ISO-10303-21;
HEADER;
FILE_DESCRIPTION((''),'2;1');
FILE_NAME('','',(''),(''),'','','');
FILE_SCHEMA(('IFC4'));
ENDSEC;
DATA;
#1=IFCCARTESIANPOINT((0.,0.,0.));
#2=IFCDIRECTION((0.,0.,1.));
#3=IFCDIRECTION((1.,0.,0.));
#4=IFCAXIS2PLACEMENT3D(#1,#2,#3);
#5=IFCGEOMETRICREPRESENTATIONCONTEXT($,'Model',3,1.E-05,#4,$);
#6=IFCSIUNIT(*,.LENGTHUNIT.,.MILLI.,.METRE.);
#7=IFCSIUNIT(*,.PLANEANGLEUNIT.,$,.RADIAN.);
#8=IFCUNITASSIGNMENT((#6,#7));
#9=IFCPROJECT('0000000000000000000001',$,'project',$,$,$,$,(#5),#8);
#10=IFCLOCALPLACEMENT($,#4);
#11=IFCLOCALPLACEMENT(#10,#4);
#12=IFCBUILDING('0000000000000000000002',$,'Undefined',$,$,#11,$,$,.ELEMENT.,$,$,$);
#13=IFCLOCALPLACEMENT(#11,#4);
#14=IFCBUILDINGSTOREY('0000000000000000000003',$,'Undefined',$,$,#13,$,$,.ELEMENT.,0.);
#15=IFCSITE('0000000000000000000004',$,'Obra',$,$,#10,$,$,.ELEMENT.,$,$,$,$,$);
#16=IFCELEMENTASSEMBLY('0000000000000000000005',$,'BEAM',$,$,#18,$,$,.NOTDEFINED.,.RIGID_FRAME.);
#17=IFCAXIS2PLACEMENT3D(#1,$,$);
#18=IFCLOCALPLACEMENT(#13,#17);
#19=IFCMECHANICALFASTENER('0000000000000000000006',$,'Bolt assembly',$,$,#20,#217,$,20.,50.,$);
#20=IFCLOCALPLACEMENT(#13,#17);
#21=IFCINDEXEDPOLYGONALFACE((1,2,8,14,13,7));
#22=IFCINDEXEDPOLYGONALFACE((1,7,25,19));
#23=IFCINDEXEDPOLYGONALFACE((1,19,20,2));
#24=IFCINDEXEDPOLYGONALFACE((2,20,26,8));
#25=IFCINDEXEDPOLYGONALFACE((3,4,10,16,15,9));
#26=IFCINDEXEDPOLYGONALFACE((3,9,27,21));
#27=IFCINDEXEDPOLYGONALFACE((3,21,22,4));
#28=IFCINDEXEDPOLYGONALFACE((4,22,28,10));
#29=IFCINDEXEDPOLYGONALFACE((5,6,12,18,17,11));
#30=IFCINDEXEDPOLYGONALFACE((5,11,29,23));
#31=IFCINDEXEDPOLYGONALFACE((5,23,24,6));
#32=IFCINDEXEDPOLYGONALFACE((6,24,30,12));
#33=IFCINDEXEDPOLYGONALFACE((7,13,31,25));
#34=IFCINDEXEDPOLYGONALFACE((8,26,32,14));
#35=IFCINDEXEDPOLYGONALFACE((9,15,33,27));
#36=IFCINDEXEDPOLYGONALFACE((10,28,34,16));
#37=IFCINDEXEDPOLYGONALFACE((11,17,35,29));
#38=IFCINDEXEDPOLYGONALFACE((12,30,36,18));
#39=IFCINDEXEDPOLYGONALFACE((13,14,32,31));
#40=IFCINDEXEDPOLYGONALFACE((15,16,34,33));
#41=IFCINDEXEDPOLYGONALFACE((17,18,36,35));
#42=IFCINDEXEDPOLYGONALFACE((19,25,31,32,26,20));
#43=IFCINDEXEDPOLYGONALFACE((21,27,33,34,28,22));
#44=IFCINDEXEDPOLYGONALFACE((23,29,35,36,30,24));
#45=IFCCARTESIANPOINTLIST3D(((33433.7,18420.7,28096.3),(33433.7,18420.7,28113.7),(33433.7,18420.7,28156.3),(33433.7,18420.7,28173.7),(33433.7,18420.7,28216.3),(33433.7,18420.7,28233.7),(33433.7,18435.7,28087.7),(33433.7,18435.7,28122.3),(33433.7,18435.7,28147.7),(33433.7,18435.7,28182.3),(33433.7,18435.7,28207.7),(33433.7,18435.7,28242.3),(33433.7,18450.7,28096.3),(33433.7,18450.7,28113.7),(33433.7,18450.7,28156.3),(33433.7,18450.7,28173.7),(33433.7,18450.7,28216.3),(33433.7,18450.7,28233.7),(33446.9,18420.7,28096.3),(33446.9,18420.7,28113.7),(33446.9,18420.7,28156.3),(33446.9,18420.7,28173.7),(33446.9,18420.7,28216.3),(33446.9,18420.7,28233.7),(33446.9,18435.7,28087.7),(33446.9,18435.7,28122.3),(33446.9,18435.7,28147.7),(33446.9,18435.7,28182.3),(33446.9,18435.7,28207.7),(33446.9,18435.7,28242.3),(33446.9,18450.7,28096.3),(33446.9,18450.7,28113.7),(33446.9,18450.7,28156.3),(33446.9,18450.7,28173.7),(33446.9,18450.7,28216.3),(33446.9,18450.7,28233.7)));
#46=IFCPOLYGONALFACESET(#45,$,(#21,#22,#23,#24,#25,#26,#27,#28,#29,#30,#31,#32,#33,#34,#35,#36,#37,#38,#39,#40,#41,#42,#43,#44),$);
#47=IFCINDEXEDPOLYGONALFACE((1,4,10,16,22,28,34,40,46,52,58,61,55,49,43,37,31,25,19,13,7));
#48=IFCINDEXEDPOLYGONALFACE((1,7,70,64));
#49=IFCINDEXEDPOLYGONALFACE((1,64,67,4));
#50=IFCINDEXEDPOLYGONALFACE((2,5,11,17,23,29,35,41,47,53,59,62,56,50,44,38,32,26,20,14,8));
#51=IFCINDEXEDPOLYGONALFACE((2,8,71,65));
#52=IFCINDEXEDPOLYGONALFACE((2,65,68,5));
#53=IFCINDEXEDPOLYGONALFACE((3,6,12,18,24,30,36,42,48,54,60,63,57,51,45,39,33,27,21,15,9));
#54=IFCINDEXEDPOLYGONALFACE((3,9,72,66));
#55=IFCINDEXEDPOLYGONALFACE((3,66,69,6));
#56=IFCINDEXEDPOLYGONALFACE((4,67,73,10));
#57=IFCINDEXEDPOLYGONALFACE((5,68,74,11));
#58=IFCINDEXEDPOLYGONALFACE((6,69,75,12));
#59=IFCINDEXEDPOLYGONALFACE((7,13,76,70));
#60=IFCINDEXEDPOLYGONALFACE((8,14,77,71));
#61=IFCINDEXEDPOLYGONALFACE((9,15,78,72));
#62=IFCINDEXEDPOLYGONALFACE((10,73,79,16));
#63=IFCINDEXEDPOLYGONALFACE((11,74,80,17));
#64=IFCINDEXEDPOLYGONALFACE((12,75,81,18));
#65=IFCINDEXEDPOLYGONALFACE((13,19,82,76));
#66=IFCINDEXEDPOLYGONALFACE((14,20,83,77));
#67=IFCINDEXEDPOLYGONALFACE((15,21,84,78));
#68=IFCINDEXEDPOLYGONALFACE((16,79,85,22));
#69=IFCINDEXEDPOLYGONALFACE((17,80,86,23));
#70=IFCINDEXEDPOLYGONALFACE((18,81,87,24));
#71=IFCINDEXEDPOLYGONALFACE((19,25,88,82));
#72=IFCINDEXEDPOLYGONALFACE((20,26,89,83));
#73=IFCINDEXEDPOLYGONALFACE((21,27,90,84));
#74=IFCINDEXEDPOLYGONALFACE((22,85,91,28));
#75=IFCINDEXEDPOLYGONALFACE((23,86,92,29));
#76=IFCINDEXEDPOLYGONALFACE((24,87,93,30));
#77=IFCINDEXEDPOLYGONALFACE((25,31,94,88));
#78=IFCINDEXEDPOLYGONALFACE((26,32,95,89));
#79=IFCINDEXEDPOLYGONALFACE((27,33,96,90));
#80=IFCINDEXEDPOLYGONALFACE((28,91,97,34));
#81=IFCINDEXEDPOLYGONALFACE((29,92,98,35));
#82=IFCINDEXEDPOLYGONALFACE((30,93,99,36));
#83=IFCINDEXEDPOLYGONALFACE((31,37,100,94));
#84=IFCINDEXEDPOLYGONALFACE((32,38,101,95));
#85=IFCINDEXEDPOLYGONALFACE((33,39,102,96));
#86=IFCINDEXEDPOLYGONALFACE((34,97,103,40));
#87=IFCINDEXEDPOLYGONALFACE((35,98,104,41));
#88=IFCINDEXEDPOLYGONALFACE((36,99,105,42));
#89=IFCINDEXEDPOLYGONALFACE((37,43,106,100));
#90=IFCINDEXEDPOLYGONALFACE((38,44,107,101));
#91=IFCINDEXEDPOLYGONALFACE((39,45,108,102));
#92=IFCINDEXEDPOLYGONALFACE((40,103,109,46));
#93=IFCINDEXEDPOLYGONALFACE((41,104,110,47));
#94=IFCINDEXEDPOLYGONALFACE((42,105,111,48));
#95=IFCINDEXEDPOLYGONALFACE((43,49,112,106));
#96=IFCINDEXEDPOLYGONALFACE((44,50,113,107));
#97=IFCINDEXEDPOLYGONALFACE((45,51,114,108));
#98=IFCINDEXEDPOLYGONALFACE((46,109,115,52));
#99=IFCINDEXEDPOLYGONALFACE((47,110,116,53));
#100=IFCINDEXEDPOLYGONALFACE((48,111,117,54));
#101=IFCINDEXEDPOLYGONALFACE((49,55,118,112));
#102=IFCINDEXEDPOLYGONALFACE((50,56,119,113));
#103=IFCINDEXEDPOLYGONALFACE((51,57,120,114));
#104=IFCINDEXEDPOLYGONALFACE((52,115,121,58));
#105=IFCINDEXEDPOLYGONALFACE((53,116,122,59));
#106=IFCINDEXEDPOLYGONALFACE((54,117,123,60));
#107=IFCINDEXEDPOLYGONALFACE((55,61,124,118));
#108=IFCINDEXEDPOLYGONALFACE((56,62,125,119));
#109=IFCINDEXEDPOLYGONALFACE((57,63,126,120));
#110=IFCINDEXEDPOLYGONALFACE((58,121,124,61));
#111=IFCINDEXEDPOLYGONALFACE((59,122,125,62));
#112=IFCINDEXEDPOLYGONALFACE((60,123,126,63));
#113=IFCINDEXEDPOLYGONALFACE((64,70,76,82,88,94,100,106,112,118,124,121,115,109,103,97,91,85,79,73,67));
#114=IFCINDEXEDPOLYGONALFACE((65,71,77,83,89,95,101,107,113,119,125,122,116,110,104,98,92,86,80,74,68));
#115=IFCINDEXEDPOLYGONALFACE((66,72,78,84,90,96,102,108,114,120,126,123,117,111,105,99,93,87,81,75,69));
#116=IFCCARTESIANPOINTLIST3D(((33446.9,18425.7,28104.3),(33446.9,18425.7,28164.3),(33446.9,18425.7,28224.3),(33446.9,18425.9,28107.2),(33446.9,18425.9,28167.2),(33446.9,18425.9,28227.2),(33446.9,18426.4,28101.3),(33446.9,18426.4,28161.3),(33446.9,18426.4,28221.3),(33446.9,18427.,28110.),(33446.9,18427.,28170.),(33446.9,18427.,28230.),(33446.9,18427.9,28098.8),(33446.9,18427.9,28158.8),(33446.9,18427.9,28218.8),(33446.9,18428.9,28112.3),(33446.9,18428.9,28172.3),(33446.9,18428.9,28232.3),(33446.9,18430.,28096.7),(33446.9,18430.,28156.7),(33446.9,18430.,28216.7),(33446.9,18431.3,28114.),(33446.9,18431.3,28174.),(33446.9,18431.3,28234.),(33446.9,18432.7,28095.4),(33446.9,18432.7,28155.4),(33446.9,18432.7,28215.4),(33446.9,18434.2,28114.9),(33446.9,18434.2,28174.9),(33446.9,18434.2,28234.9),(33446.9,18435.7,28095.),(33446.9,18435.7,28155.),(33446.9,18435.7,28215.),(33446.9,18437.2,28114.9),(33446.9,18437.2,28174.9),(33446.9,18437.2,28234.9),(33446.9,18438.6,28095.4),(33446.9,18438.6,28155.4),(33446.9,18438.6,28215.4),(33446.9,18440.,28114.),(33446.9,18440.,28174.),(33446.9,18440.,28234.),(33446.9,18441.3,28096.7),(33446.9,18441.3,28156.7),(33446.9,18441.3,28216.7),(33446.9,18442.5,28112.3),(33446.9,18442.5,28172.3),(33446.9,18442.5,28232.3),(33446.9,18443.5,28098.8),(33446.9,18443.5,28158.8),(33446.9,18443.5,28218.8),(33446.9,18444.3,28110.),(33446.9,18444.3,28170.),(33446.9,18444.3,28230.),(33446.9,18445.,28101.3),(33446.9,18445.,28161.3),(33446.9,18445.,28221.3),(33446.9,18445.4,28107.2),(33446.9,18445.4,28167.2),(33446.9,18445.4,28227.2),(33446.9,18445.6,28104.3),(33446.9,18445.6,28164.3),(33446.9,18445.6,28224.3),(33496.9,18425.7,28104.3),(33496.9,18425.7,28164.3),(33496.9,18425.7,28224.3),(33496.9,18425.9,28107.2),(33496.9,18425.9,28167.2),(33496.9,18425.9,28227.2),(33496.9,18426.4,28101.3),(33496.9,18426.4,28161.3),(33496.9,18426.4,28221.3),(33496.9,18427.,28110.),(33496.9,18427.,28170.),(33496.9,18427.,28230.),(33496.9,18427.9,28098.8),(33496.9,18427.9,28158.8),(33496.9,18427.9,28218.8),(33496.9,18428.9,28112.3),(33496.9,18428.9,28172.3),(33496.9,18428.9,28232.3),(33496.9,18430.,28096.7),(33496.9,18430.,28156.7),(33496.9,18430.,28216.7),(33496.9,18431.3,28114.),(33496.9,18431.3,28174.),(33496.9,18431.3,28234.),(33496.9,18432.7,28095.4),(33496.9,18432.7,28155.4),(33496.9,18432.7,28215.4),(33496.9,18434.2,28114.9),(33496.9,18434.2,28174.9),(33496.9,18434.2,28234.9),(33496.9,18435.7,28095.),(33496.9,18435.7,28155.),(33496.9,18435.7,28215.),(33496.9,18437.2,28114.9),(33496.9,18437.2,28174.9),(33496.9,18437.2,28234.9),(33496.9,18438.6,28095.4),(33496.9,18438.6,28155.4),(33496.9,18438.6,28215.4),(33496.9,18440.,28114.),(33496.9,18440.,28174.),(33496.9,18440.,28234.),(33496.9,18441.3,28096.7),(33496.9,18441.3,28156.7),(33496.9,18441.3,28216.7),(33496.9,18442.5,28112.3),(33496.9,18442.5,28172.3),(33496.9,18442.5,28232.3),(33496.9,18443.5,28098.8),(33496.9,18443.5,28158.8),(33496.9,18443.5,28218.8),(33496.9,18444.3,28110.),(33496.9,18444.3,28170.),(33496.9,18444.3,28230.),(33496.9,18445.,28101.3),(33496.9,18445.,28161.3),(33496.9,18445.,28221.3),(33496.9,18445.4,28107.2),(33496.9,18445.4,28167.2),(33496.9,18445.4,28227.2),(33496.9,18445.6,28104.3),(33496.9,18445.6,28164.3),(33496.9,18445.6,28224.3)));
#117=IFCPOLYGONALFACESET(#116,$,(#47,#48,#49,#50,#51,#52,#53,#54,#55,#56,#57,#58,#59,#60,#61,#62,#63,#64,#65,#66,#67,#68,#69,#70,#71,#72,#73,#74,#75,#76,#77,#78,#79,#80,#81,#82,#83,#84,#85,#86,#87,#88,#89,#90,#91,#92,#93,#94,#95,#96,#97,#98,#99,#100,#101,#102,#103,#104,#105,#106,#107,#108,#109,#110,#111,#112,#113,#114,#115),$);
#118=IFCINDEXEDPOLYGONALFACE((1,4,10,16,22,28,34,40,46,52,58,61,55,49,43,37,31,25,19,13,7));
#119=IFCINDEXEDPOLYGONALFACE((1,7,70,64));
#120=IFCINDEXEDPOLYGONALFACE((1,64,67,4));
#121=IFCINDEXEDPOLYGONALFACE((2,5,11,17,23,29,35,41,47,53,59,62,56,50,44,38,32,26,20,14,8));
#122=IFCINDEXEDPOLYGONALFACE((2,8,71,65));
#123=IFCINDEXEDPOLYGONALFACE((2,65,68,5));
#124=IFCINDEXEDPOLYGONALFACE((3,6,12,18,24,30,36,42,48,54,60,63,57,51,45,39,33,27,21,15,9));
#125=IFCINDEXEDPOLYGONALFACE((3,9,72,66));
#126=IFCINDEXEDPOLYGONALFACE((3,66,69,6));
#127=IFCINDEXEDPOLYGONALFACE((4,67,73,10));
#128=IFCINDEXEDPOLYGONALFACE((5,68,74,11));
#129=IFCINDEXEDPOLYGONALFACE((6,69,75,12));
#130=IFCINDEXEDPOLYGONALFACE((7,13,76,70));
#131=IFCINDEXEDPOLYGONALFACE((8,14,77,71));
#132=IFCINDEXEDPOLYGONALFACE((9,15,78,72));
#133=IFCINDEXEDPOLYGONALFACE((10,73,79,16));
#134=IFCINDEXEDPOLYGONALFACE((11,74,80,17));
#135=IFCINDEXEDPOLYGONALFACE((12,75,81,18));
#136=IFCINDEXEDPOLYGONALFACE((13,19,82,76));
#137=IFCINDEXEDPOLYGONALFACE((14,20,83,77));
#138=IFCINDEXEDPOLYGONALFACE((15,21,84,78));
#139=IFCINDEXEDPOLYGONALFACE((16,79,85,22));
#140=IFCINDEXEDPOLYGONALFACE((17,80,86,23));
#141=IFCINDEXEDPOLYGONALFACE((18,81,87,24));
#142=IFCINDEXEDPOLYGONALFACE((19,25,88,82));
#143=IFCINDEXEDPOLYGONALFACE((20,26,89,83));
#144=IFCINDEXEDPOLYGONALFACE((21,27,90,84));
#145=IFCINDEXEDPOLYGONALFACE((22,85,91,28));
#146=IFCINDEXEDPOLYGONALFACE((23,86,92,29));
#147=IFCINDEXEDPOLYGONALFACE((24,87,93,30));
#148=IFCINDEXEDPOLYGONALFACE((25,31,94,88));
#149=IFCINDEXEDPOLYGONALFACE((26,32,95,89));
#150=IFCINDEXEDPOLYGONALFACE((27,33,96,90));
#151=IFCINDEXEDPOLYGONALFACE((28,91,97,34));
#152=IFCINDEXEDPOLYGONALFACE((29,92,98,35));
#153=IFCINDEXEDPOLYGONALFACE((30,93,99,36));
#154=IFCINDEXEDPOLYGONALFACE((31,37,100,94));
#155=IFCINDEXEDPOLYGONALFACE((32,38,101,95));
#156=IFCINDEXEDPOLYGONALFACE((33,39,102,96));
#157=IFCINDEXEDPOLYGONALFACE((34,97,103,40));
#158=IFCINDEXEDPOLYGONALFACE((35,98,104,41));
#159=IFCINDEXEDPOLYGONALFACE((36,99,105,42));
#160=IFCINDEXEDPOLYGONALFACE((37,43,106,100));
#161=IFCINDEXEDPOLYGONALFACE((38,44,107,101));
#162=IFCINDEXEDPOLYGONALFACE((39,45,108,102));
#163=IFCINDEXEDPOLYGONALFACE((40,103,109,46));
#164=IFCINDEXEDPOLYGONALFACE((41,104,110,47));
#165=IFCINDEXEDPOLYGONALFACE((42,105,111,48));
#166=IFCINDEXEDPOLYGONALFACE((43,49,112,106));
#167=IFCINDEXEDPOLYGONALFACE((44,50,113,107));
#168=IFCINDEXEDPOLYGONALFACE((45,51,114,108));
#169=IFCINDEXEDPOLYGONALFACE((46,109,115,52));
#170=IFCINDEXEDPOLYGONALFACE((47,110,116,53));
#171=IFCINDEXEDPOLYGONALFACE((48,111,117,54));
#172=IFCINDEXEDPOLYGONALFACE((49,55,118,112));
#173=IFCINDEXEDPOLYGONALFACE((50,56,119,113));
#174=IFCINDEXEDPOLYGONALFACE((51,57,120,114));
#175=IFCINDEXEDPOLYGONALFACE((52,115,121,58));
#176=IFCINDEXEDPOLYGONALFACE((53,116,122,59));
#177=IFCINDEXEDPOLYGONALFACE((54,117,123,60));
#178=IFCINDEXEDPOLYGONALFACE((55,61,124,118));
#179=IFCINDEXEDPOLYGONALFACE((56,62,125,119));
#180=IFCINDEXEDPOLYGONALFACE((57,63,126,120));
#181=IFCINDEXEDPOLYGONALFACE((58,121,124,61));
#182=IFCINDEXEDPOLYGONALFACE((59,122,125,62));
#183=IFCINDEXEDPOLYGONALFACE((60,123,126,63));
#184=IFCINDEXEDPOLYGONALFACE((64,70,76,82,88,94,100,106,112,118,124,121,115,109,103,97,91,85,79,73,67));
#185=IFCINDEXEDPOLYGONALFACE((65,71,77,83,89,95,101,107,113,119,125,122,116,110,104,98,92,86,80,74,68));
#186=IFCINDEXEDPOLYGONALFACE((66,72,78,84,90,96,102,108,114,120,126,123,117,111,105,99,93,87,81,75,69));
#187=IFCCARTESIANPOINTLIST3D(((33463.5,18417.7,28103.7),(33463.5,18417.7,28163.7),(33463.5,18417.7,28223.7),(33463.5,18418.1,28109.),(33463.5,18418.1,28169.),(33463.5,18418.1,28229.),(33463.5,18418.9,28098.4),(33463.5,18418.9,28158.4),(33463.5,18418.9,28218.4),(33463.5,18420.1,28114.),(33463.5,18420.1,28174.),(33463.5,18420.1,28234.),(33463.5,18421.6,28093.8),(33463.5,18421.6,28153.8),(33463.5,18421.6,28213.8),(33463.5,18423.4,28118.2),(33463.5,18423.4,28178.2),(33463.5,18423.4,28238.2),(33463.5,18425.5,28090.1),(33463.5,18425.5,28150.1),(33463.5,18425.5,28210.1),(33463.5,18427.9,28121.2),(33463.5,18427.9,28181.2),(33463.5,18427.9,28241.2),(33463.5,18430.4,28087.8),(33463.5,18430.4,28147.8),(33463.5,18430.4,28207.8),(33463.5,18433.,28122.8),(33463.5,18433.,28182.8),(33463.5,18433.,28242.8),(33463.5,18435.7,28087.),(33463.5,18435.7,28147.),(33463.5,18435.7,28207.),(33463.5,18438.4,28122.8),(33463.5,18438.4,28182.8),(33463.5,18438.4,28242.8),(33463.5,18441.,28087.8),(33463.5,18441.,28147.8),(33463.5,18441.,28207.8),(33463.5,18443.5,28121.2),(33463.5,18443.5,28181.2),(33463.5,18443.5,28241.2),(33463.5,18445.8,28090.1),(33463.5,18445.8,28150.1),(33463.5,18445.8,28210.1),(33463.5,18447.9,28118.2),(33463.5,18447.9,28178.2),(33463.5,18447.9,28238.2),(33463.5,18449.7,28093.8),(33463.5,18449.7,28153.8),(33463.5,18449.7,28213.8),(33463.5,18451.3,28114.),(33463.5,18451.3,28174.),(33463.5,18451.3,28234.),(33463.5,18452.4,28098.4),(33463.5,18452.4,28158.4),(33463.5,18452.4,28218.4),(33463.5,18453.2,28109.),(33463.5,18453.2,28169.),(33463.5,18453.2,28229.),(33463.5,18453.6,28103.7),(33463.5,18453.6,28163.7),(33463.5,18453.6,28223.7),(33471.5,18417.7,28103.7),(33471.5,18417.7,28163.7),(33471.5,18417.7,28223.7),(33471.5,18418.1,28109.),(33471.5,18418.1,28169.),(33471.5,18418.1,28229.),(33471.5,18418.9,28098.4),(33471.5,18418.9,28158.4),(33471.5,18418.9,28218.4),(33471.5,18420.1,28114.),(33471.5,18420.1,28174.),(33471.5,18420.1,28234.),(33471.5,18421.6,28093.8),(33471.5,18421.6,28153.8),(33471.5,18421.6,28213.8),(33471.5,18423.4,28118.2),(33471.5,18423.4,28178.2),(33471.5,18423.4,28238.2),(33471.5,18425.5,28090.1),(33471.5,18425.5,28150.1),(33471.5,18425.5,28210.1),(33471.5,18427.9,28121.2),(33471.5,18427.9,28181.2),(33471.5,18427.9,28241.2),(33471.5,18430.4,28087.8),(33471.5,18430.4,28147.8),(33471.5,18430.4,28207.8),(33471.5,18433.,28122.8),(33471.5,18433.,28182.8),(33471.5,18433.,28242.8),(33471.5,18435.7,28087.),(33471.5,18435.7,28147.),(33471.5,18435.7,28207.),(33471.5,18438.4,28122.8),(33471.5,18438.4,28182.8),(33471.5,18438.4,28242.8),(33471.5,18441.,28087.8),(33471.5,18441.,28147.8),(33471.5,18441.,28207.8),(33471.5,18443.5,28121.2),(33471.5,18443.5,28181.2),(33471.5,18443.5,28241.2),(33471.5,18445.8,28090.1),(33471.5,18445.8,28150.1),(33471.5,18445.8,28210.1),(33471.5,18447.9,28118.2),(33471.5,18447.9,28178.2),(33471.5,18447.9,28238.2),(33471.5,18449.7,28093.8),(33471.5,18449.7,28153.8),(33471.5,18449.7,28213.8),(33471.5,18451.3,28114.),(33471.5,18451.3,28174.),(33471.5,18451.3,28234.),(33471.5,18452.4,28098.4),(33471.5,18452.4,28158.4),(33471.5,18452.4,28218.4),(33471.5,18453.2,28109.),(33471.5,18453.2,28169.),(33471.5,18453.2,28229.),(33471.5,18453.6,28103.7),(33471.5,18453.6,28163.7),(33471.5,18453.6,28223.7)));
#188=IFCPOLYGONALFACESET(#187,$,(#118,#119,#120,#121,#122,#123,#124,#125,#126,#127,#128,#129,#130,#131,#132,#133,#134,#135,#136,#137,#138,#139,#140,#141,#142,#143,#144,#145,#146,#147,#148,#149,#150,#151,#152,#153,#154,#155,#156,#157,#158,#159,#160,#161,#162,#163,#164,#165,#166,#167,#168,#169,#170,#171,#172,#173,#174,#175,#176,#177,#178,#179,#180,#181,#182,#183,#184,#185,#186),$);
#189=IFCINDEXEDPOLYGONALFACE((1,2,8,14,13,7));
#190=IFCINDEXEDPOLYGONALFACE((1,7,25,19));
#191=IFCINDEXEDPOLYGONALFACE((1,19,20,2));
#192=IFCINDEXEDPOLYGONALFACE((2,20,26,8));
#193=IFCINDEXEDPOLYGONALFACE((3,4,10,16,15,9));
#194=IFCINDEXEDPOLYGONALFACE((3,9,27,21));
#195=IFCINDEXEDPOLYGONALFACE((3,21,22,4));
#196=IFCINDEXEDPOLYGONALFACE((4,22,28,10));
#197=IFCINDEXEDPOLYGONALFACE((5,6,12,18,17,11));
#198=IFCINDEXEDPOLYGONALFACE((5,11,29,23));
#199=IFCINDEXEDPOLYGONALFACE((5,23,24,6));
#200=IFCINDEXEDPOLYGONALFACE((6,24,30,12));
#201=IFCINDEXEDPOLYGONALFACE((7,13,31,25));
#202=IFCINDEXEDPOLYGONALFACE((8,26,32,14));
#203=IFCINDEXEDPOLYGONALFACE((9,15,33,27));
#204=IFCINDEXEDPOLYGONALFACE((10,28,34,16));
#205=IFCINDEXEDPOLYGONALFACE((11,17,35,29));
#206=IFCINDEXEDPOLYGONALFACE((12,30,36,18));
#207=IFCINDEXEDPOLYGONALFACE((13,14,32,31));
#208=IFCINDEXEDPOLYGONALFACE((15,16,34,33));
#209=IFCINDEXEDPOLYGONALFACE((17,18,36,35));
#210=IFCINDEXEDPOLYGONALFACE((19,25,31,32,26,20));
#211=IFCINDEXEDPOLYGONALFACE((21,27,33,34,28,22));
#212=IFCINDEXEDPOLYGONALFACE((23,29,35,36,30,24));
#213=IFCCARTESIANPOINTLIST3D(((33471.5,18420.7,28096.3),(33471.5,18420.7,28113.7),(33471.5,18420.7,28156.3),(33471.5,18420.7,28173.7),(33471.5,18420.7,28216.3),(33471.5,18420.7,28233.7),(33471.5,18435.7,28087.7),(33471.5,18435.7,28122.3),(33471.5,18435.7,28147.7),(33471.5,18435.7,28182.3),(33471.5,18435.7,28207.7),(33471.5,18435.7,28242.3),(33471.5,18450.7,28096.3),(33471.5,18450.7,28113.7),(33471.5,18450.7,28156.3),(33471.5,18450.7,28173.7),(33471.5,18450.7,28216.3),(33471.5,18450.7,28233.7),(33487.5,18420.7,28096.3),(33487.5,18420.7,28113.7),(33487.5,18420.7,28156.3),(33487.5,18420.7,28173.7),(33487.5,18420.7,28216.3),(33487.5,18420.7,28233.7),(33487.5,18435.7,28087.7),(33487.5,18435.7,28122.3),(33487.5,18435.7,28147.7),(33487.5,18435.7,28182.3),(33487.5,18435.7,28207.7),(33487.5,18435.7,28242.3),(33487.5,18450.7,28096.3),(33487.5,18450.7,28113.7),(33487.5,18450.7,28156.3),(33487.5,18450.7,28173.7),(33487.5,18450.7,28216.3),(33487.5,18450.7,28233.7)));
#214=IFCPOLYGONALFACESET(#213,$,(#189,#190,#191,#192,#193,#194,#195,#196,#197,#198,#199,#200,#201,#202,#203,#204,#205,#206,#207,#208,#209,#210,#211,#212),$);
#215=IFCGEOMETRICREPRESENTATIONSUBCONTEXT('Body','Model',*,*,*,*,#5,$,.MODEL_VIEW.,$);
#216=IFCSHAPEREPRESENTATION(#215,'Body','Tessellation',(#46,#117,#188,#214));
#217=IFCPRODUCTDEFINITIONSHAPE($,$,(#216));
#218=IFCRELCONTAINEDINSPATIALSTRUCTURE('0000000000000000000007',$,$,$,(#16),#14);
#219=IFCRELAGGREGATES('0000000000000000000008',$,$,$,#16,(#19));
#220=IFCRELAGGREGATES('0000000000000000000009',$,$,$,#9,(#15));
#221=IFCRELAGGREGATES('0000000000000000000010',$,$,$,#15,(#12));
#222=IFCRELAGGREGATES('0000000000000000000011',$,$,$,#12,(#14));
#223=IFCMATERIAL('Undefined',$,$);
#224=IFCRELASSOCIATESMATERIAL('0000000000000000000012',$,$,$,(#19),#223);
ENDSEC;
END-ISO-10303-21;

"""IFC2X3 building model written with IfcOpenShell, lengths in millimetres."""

from ifc_helpers import new_model, si_unit, frame, origin_with_axes, origin_2d_with_axis, place, context, subcontext, project, spatial, polyline, circle, outline, extrude, source, transform, mapped, material, element, aggregate, save


model = new_model("IFC2X3")

# Units and contexts
model_context = context("Model", 3, precision=1e-05, world=origin_with_axes())
body_context = subcontext(model_context, "Body", "Model", "MODEL_VIEW")
ifc_project = project(units=[si_unit("LENGTHUNIT", "METRE", prefix="MILLI"), si_unit("PLANEANGLEUNIT", "RADIAN")], contexts=[model_context])

# Site, building, storey
site_placement = place(None, origin_with_axes())
site = spatial("IfcSite", under=ifc_project, at=site_placement, Name="Obra", CompositionType="ELEMENT")
building_placement = place(site_placement, origin_with_axes())
building = spatial("IfcBuilding", under=site, at=building_placement, Name="Undefined", CompositionType="ELEMENT")
storey_placement = place(building_placement, origin_with_axes())
storey = spatial("IfcBuildingStorey", under=building, at=storey_placement, Name="Undefined", CompositionType="ELEMENT", Elevation=0.0)

# Element assembly, mechanical fastener
ifc_material_1 = material(Name="Undefined")
shared_shape_1 = source(origin_with_axes(), body_context, "Body", "SweptSolid", [
    extrude(outline(polyline([(17.3, 0.0), (8.7, 15.0), (-8.7, 15.0), (-17.3, 0.0), (-8.7, -15.0), (8.7, -15.0), (17.3, 0.0)])), frame((0.0, -26.5, 0.0), z_axis=(0.0, 1.0, 0.0), x_axis=(1.0, 0.0, 0.0)), (0.0, 0.0, 1.0), 13.2),
    extrude(circle(Radius=10.0, at=origin_2d_with_axis()), frame((0.0, -13.3, 0.0), z_axis=(0.0, 1.0, 0.0), x_axis=(1.0, 0.0, 0.0)), (0.0, 0.0, 1.0), 50.0),
    extrude(circle(Radius=18.0, at=origin_2d_with_axis()), frame((0.0, 3.3, 0.0), z_axis=(0.0, 1.0, 0.0), x_axis=(1.0, 0.0, 0.0)), (0.0, 0.0, 1.0), 8.0),
    extrude(outline(polyline([(17.3, 0.0), (8.7, 15.0), (-8.7, 15.0), (-17.3, 0.0), (-8.7, -15.0), (8.7, -15.0), (17.3, 0.0)])), frame((0.0, 11.3, 0.0), z_axis=(0.0, 1.0, 0.0), x_axis=(1.0, 0.0, 0.0)), (0.0, 0.0, 1.0), 16.0),
])
assembly_1_placement = place(storey_placement, origin_with_axes())
assembly_1 = element("IfcElementAssembly", 1, at=assembly_1_placement, inside=storey, Name="BEAM", AssemblyPlace="NOTDEFINED", PredefinedType="RIGID_FRAME")
mechanical_fastener_1_placement = place(assembly_1_placement, frame((33460.2, 18485.7, 28265.0), z_axis=(0.0, -1.0, 0.0), x_axis=(0.0, 0.0, -1.0)))
mechanical_fastener_1 = element("IfcMechanicalFastener", 2, at=mechanical_fastener_1_placement, material=ifc_material_1, Name="Bolt assembly", NominalDiameter=20.0, NominalLength=50.0, context=body_context, shape_type="MappedRepresentation", body=[
    mapped(shared_shape_1, transform((40.0, 0.0, 50.0))),
    mapped(shared_shape_1, transform((100.0, 0.0, 50.0))),
    mapped(shared_shape_1, transform((160.0, 0.0, 50.0))),
])
aggregate(assembly_1, [mechanical_fastener_1])

save(model, "model.ifc")
